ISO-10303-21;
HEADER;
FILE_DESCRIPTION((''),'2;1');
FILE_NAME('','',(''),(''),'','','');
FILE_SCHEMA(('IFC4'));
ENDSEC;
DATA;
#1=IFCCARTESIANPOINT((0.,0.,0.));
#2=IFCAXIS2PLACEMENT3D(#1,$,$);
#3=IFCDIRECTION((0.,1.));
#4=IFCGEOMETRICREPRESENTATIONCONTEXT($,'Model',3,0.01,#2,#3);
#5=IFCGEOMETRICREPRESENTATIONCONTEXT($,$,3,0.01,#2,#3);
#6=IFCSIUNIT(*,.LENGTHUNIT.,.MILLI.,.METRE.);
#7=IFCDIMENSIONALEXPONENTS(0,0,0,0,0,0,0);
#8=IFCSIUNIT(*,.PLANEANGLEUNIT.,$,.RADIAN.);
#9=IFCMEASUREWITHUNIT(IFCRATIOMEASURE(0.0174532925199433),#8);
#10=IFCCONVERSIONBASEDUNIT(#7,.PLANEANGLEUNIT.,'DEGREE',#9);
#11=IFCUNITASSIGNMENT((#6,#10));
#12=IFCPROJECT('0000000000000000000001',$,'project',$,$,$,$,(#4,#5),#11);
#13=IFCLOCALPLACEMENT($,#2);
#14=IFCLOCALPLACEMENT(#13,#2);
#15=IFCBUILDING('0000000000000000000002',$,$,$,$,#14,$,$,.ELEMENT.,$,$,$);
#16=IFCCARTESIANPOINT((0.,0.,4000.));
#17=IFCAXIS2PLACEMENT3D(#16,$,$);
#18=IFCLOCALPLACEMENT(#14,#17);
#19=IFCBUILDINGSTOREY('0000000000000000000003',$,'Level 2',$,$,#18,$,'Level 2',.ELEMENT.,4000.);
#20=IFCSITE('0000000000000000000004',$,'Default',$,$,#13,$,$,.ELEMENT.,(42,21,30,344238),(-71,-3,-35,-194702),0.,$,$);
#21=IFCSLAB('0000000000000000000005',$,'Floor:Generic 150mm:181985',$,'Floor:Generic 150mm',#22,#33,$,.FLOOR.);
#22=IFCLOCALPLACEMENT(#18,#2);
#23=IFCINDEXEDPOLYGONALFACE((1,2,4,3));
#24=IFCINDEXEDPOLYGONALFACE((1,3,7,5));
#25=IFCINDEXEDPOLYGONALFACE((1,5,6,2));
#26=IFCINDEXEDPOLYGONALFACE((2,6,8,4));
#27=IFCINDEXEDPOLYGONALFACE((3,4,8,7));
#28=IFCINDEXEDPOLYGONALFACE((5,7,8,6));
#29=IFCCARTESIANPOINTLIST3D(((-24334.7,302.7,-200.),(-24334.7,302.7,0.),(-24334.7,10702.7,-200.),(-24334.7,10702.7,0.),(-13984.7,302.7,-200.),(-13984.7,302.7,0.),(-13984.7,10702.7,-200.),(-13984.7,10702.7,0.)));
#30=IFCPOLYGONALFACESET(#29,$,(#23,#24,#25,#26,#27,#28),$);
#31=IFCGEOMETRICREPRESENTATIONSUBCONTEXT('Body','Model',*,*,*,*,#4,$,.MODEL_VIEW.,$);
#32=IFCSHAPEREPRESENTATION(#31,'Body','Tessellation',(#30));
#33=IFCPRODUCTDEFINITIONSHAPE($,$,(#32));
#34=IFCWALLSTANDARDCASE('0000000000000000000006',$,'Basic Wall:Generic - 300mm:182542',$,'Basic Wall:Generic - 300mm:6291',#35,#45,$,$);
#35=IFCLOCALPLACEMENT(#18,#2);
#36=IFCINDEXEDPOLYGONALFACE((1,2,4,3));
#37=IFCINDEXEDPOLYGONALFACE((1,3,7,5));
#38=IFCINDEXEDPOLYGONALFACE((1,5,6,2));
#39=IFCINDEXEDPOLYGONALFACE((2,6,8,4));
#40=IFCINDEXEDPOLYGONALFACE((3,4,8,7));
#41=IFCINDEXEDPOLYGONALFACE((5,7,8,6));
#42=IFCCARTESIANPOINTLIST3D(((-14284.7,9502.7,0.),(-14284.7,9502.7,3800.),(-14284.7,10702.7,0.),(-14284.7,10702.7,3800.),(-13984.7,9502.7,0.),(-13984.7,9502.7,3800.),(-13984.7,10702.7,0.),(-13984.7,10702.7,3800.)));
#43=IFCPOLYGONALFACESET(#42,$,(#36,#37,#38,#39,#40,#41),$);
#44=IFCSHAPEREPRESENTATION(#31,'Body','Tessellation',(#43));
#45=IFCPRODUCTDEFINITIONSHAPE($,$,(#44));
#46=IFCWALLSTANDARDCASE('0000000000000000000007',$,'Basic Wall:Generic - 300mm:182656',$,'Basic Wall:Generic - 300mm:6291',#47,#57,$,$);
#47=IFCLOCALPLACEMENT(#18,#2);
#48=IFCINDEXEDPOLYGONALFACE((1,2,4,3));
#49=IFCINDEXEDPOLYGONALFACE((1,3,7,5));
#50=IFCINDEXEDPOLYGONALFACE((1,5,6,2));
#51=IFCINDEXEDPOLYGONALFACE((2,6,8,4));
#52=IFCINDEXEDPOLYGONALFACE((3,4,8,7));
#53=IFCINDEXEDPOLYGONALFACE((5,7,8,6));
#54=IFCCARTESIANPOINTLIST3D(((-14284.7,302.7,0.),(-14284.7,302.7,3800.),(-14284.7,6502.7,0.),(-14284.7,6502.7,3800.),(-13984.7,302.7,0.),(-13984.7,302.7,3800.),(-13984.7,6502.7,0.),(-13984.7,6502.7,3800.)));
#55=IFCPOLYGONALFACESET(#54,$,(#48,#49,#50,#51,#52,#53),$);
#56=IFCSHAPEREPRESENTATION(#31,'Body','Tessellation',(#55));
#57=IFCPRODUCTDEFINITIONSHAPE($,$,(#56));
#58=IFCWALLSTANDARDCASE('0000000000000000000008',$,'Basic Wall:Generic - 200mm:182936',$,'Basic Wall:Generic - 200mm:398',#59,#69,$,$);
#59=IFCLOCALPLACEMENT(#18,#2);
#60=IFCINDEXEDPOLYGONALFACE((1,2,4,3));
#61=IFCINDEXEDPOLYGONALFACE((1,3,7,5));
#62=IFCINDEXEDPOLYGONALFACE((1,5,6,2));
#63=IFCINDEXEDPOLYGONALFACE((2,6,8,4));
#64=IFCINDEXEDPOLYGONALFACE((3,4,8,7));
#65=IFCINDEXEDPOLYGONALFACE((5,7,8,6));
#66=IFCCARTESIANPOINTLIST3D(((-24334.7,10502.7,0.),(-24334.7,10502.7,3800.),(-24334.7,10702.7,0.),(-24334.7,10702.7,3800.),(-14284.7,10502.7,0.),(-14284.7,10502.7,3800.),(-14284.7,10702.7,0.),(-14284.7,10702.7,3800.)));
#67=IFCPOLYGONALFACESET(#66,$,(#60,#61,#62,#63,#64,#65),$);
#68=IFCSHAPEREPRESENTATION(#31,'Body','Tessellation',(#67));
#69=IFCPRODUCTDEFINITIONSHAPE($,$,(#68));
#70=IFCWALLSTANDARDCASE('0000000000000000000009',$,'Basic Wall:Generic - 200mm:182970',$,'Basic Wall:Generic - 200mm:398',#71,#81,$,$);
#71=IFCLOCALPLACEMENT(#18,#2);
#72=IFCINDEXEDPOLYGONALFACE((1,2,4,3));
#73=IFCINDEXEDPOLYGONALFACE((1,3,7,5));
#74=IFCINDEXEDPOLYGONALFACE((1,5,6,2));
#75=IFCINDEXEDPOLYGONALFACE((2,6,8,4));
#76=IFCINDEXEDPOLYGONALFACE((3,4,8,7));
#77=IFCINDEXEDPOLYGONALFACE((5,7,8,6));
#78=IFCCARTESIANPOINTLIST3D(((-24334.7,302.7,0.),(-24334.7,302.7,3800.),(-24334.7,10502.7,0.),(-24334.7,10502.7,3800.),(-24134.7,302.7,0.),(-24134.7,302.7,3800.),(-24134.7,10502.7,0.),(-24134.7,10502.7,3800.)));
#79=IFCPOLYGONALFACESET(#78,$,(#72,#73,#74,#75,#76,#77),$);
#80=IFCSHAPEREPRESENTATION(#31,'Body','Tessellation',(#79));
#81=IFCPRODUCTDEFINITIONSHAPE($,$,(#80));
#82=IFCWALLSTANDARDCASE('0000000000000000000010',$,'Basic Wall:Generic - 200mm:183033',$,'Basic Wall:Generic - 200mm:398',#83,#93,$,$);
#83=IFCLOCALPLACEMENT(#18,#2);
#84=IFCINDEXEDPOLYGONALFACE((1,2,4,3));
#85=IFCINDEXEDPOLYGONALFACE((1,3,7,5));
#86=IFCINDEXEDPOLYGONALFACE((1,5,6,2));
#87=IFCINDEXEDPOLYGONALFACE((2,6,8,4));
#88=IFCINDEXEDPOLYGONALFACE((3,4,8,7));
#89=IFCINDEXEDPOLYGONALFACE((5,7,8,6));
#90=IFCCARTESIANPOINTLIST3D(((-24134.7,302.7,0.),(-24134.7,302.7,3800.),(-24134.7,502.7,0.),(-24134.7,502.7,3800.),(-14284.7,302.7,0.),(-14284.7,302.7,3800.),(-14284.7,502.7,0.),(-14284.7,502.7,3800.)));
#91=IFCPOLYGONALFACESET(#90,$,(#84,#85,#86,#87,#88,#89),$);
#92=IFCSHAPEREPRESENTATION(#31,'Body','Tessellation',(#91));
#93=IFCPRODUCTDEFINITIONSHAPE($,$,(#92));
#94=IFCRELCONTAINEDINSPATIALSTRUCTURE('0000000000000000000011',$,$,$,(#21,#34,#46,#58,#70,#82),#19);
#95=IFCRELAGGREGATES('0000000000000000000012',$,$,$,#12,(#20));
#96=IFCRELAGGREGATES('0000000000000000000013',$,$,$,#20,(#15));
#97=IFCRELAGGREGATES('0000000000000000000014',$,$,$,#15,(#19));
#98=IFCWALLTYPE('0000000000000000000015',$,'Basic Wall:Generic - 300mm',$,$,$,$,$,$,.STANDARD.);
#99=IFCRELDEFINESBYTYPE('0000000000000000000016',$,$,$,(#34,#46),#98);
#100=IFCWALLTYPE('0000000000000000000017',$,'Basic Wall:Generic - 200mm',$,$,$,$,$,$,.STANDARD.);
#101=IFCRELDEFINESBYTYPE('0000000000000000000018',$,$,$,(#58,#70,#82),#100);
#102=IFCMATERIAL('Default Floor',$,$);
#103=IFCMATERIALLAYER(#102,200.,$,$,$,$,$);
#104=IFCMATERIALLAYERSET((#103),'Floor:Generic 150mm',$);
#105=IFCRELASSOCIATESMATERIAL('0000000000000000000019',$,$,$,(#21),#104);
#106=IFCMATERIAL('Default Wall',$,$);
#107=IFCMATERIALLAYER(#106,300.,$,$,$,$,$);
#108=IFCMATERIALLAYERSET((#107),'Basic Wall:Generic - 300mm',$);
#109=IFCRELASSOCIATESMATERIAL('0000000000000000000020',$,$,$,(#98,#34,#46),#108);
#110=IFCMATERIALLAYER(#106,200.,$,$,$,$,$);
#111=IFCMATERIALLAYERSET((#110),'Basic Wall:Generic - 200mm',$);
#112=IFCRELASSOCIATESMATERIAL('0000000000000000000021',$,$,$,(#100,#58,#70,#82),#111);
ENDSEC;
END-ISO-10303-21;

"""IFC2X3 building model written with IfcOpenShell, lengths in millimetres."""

from ifc_helpers import new_model, entity, si_unit, converted_unit, direction, frame, frame_2d, origin, place, context, subcontext, project, spatial, rectangle, extrude, material, layer, layer_set, layer_usage, type_object, element, save


model = new_model("IFC2X3")

# Units and contexts
model_context = context("Model", 3, precision=0.01, world=origin(), true_north=direction((0.0, 1.0)))
context_of_model = context(None, 3, precision=0.01, world=origin(), true_north=direction((0.0, 1.0)))
body_context = subcontext(model_context, "Body", "Model", "MODEL_VIEW")
ifc_project = project(units=[si_unit("LENGTHUNIT", "METRE", prefix="MILLI"), converted_unit("PLANEANGLEUNIT", "DEGREE", entity("IfcRatioMeasure", 0.0174532925199433), si_unit("PLANEANGLEUNIT", "RADIAN"), dimensions=[0, 0, 0, 0, 0, 0, 0])], contexts=[model_context, context_of_model])

# Site, building, storey
site_placement = place(None, origin())
site = spatial("IfcSite", under=ifc_project, at=site_placement, Name="Default", CompositionType="ELEMENT", RefLatitude=(42, 21, 30, 344238), RefLongitude=(-71, -3, -35, -194702), RefElevation=0.0)
building_placement = place(site_placement, origin())
building = spatial("IfcBuilding", under=site, at=building_placement, CompositionType="ELEMENT")
storey_placement = place(building_placement, frame((0.0, 0.0, 4000.0)))
storey = spatial("IfcBuildingStorey", under=building, at=storey_placement, Name="Level 2", LongName="Level 2", CompositionType="ELEMENT", Elevation=4000.0)

# Slab
ifc_material_1 = material(Name="Default Floor")
ifc_layer_1 = layer(ifc_material_1, 200.0)
ifc_layer_set_1 = layer_set([ifc_layer_1], Name="Floor:Generic 150mm")
ifc_layer_usage_1 = layer_usage(ifc_layer_set_1, "AXIS3", "POSITIVE", 0.0)
slab_placement = place(storey_placement, origin())
element("IfcSlab", 1, at=slab_placement, inside=storey, material=ifc_layer_usage_1, Name="Floor:Generic 150mm:181985", ObjectType="Floor:Generic 150mm", PredefinedType="FLOOR", context=body_context, shape_type="SweptSolid", body=[
    extrude(rectangle(XDim=10400.0, YDim=10350.0, at=frame_2d((0.0, 0.0), x_axis=(1.0, 0.0))), frame((-19159.7, 5502.7, 0.0), z_axis=(0.0, 0.0, -1.0), x_axis=(0.0, 1.0, 0.0)), (0.0, 0.0, 1.0), 200.0),
])

# Walls
ifc_material_2 = material(Name="Default Wall")
ifc_layer_2 = layer(ifc_material_2, 300.0)
ifc_layer_set_2 = layer_set([ifc_layer_2], Name="Basic Wall:Generic - 300mm")
ifc_layer_usage_2 = layer_usage(ifc_layer_set_2, "AXIS2", "NEGATIVE", 150.0)
wall_type_1 = type_object("IfcWallType", Name="Basic Wall:Generic - 300mm", PredefinedType="STANDARD", material=ifc_layer_set_2)
wall_1_placement = place(storey_placement, frame((-14134.7, 10702.7, 0.0), z_axis=(0.0, 0.0, 1.0), x_axis=(0.0, -1.0, 0.0)))
element("IfcWallStandardCase", 2, at=wall_1_placement, inside=storey, type_object=wall_type_1, material=ifc_layer_usage_2, Name="Basic Wall:Generic - 300mm:182542", ObjectType="Basic Wall:Generic - 300mm:6291", context=body_context, shape_type="SweptSolid", body=[
    extrude(rectangle(XDim=1200.0, YDim=300.0, at=frame_2d((600.0, 0.0), x_axis=(-1.0, 0.0))), origin(), (0.0, 0.0, 1.0), 3800.0),
])
ifc_layer_usage_3 = layer_usage(ifc_layer_set_2, "AXIS2", "NEGATIVE", 150.0)
wall_2_placement = place(storey_placement, frame((-14134.7, 302.7, 0.0), z_axis=(0.0, 0.0, 1.0), x_axis=(0.0, 1.0, 0.0)))
element("IfcWallStandardCase", 3, at=wall_2_placement, inside=storey, type_object=wall_type_1, material=ifc_layer_usage_3, Name="Basic Wall:Generic - 300mm:182656", ObjectType="Basic Wall:Generic - 300mm:6291", context=body_context, shape_type="SweptSolid", body=[
    extrude(rectangle(XDim=6200.0, YDim=300.0, at=frame_2d((3100.0, 0.0), x_axis=(-1.0, 0.0))), origin(), (0.0, 0.0, 1.0), 3800.0),
])
ifc_layer_3 = layer(ifc_material_2, 200.0)
ifc_layer_set_3 = layer_set([ifc_layer_3], Name="Basic Wall:Generic - 200mm")
ifc_layer_usage_4 = layer_usage(ifc_layer_set_3, "AXIS2", "NEGATIVE", 100.0)
wall_type_2 = type_object("IfcWallType", Name="Basic Wall:Generic - 200mm", PredefinedType="STANDARD", material=ifc_layer_set_3)
wall_3_placement = place(storey_placement, frame((-14284.7, 10602.7, 0.0), z_axis=(0.0, 0.0, 1.0), x_axis=(-1.0, 0.0, 0.0)))
element("IfcWallStandardCase", 4, at=wall_3_placement, inside=storey, type_object=wall_type_2, material=ifc_layer_usage_4, Name="Basic Wall:Generic - 200mm:182936", ObjectType="Basic Wall:Generic - 200mm:398", context=body_context, shape_type="SweptSolid", body=[
    extrude(rectangle(XDim=10050.0, YDim=200.0, at=frame_2d((5025.0, 0.0), x_axis=(-1.0, 0.0))), origin(), (0.0, 0.0, 1.0), 3800.0),
])
ifc_layer_usage_5 = layer_usage(ifc_layer_set_3, "AXIS2", "NEGATIVE", 100.0)
wall_4_placement = place(storey_placement, frame((-24234.7, 10502.7, 0.0), z_axis=(0.0, 0.0, 1.0), x_axis=(0.0, -1.0, 0.0)))
element("IfcWallStandardCase", 5, at=wall_4_placement, inside=storey, type_object=wall_type_2, material=ifc_layer_usage_5, Name="Basic Wall:Generic - 200mm:182970", ObjectType="Basic Wall:Generic - 200mm:398", context=body_context, shape_type="SweptSolid", body=[
    extrude(rectangle(XDim=10200.0, YDim=200.0, at=frame_2d((5100.0, 0.0), x_axis=(-1.0, 0.0))), origin(), (0.0, 0.0, 1.0), 3800.0),
])
ifc_layer_usage_6 = layer_usage(ifc_layer_set_3, "AXIS2", "NEGATIVE", 100.0)
wall_5_placement = place(storey_placement, frame((-24134.7, 402.7, 0.0)))
element("IfcWallStandardCase", 6, at=wall_5_placement, inside=storey, type_object=wall_type_2, material=ifc_layer_usage_6, Name="Basic Wall:Generic - 200mm:183033", ObjectType="Basic Wall:Generic - 200mm:398", context=body_context, shape_type="SweptSolid", body=[
    extrude(rectangle(XDim=9850.0, YDim=200.0, at=frame_2d((4925.0, 0.0), x_axis=(-1.0, 0.0))), origin(), (0.0, 0.0, 1.0), 3800.0),
])

save(model, "model.ifc")
